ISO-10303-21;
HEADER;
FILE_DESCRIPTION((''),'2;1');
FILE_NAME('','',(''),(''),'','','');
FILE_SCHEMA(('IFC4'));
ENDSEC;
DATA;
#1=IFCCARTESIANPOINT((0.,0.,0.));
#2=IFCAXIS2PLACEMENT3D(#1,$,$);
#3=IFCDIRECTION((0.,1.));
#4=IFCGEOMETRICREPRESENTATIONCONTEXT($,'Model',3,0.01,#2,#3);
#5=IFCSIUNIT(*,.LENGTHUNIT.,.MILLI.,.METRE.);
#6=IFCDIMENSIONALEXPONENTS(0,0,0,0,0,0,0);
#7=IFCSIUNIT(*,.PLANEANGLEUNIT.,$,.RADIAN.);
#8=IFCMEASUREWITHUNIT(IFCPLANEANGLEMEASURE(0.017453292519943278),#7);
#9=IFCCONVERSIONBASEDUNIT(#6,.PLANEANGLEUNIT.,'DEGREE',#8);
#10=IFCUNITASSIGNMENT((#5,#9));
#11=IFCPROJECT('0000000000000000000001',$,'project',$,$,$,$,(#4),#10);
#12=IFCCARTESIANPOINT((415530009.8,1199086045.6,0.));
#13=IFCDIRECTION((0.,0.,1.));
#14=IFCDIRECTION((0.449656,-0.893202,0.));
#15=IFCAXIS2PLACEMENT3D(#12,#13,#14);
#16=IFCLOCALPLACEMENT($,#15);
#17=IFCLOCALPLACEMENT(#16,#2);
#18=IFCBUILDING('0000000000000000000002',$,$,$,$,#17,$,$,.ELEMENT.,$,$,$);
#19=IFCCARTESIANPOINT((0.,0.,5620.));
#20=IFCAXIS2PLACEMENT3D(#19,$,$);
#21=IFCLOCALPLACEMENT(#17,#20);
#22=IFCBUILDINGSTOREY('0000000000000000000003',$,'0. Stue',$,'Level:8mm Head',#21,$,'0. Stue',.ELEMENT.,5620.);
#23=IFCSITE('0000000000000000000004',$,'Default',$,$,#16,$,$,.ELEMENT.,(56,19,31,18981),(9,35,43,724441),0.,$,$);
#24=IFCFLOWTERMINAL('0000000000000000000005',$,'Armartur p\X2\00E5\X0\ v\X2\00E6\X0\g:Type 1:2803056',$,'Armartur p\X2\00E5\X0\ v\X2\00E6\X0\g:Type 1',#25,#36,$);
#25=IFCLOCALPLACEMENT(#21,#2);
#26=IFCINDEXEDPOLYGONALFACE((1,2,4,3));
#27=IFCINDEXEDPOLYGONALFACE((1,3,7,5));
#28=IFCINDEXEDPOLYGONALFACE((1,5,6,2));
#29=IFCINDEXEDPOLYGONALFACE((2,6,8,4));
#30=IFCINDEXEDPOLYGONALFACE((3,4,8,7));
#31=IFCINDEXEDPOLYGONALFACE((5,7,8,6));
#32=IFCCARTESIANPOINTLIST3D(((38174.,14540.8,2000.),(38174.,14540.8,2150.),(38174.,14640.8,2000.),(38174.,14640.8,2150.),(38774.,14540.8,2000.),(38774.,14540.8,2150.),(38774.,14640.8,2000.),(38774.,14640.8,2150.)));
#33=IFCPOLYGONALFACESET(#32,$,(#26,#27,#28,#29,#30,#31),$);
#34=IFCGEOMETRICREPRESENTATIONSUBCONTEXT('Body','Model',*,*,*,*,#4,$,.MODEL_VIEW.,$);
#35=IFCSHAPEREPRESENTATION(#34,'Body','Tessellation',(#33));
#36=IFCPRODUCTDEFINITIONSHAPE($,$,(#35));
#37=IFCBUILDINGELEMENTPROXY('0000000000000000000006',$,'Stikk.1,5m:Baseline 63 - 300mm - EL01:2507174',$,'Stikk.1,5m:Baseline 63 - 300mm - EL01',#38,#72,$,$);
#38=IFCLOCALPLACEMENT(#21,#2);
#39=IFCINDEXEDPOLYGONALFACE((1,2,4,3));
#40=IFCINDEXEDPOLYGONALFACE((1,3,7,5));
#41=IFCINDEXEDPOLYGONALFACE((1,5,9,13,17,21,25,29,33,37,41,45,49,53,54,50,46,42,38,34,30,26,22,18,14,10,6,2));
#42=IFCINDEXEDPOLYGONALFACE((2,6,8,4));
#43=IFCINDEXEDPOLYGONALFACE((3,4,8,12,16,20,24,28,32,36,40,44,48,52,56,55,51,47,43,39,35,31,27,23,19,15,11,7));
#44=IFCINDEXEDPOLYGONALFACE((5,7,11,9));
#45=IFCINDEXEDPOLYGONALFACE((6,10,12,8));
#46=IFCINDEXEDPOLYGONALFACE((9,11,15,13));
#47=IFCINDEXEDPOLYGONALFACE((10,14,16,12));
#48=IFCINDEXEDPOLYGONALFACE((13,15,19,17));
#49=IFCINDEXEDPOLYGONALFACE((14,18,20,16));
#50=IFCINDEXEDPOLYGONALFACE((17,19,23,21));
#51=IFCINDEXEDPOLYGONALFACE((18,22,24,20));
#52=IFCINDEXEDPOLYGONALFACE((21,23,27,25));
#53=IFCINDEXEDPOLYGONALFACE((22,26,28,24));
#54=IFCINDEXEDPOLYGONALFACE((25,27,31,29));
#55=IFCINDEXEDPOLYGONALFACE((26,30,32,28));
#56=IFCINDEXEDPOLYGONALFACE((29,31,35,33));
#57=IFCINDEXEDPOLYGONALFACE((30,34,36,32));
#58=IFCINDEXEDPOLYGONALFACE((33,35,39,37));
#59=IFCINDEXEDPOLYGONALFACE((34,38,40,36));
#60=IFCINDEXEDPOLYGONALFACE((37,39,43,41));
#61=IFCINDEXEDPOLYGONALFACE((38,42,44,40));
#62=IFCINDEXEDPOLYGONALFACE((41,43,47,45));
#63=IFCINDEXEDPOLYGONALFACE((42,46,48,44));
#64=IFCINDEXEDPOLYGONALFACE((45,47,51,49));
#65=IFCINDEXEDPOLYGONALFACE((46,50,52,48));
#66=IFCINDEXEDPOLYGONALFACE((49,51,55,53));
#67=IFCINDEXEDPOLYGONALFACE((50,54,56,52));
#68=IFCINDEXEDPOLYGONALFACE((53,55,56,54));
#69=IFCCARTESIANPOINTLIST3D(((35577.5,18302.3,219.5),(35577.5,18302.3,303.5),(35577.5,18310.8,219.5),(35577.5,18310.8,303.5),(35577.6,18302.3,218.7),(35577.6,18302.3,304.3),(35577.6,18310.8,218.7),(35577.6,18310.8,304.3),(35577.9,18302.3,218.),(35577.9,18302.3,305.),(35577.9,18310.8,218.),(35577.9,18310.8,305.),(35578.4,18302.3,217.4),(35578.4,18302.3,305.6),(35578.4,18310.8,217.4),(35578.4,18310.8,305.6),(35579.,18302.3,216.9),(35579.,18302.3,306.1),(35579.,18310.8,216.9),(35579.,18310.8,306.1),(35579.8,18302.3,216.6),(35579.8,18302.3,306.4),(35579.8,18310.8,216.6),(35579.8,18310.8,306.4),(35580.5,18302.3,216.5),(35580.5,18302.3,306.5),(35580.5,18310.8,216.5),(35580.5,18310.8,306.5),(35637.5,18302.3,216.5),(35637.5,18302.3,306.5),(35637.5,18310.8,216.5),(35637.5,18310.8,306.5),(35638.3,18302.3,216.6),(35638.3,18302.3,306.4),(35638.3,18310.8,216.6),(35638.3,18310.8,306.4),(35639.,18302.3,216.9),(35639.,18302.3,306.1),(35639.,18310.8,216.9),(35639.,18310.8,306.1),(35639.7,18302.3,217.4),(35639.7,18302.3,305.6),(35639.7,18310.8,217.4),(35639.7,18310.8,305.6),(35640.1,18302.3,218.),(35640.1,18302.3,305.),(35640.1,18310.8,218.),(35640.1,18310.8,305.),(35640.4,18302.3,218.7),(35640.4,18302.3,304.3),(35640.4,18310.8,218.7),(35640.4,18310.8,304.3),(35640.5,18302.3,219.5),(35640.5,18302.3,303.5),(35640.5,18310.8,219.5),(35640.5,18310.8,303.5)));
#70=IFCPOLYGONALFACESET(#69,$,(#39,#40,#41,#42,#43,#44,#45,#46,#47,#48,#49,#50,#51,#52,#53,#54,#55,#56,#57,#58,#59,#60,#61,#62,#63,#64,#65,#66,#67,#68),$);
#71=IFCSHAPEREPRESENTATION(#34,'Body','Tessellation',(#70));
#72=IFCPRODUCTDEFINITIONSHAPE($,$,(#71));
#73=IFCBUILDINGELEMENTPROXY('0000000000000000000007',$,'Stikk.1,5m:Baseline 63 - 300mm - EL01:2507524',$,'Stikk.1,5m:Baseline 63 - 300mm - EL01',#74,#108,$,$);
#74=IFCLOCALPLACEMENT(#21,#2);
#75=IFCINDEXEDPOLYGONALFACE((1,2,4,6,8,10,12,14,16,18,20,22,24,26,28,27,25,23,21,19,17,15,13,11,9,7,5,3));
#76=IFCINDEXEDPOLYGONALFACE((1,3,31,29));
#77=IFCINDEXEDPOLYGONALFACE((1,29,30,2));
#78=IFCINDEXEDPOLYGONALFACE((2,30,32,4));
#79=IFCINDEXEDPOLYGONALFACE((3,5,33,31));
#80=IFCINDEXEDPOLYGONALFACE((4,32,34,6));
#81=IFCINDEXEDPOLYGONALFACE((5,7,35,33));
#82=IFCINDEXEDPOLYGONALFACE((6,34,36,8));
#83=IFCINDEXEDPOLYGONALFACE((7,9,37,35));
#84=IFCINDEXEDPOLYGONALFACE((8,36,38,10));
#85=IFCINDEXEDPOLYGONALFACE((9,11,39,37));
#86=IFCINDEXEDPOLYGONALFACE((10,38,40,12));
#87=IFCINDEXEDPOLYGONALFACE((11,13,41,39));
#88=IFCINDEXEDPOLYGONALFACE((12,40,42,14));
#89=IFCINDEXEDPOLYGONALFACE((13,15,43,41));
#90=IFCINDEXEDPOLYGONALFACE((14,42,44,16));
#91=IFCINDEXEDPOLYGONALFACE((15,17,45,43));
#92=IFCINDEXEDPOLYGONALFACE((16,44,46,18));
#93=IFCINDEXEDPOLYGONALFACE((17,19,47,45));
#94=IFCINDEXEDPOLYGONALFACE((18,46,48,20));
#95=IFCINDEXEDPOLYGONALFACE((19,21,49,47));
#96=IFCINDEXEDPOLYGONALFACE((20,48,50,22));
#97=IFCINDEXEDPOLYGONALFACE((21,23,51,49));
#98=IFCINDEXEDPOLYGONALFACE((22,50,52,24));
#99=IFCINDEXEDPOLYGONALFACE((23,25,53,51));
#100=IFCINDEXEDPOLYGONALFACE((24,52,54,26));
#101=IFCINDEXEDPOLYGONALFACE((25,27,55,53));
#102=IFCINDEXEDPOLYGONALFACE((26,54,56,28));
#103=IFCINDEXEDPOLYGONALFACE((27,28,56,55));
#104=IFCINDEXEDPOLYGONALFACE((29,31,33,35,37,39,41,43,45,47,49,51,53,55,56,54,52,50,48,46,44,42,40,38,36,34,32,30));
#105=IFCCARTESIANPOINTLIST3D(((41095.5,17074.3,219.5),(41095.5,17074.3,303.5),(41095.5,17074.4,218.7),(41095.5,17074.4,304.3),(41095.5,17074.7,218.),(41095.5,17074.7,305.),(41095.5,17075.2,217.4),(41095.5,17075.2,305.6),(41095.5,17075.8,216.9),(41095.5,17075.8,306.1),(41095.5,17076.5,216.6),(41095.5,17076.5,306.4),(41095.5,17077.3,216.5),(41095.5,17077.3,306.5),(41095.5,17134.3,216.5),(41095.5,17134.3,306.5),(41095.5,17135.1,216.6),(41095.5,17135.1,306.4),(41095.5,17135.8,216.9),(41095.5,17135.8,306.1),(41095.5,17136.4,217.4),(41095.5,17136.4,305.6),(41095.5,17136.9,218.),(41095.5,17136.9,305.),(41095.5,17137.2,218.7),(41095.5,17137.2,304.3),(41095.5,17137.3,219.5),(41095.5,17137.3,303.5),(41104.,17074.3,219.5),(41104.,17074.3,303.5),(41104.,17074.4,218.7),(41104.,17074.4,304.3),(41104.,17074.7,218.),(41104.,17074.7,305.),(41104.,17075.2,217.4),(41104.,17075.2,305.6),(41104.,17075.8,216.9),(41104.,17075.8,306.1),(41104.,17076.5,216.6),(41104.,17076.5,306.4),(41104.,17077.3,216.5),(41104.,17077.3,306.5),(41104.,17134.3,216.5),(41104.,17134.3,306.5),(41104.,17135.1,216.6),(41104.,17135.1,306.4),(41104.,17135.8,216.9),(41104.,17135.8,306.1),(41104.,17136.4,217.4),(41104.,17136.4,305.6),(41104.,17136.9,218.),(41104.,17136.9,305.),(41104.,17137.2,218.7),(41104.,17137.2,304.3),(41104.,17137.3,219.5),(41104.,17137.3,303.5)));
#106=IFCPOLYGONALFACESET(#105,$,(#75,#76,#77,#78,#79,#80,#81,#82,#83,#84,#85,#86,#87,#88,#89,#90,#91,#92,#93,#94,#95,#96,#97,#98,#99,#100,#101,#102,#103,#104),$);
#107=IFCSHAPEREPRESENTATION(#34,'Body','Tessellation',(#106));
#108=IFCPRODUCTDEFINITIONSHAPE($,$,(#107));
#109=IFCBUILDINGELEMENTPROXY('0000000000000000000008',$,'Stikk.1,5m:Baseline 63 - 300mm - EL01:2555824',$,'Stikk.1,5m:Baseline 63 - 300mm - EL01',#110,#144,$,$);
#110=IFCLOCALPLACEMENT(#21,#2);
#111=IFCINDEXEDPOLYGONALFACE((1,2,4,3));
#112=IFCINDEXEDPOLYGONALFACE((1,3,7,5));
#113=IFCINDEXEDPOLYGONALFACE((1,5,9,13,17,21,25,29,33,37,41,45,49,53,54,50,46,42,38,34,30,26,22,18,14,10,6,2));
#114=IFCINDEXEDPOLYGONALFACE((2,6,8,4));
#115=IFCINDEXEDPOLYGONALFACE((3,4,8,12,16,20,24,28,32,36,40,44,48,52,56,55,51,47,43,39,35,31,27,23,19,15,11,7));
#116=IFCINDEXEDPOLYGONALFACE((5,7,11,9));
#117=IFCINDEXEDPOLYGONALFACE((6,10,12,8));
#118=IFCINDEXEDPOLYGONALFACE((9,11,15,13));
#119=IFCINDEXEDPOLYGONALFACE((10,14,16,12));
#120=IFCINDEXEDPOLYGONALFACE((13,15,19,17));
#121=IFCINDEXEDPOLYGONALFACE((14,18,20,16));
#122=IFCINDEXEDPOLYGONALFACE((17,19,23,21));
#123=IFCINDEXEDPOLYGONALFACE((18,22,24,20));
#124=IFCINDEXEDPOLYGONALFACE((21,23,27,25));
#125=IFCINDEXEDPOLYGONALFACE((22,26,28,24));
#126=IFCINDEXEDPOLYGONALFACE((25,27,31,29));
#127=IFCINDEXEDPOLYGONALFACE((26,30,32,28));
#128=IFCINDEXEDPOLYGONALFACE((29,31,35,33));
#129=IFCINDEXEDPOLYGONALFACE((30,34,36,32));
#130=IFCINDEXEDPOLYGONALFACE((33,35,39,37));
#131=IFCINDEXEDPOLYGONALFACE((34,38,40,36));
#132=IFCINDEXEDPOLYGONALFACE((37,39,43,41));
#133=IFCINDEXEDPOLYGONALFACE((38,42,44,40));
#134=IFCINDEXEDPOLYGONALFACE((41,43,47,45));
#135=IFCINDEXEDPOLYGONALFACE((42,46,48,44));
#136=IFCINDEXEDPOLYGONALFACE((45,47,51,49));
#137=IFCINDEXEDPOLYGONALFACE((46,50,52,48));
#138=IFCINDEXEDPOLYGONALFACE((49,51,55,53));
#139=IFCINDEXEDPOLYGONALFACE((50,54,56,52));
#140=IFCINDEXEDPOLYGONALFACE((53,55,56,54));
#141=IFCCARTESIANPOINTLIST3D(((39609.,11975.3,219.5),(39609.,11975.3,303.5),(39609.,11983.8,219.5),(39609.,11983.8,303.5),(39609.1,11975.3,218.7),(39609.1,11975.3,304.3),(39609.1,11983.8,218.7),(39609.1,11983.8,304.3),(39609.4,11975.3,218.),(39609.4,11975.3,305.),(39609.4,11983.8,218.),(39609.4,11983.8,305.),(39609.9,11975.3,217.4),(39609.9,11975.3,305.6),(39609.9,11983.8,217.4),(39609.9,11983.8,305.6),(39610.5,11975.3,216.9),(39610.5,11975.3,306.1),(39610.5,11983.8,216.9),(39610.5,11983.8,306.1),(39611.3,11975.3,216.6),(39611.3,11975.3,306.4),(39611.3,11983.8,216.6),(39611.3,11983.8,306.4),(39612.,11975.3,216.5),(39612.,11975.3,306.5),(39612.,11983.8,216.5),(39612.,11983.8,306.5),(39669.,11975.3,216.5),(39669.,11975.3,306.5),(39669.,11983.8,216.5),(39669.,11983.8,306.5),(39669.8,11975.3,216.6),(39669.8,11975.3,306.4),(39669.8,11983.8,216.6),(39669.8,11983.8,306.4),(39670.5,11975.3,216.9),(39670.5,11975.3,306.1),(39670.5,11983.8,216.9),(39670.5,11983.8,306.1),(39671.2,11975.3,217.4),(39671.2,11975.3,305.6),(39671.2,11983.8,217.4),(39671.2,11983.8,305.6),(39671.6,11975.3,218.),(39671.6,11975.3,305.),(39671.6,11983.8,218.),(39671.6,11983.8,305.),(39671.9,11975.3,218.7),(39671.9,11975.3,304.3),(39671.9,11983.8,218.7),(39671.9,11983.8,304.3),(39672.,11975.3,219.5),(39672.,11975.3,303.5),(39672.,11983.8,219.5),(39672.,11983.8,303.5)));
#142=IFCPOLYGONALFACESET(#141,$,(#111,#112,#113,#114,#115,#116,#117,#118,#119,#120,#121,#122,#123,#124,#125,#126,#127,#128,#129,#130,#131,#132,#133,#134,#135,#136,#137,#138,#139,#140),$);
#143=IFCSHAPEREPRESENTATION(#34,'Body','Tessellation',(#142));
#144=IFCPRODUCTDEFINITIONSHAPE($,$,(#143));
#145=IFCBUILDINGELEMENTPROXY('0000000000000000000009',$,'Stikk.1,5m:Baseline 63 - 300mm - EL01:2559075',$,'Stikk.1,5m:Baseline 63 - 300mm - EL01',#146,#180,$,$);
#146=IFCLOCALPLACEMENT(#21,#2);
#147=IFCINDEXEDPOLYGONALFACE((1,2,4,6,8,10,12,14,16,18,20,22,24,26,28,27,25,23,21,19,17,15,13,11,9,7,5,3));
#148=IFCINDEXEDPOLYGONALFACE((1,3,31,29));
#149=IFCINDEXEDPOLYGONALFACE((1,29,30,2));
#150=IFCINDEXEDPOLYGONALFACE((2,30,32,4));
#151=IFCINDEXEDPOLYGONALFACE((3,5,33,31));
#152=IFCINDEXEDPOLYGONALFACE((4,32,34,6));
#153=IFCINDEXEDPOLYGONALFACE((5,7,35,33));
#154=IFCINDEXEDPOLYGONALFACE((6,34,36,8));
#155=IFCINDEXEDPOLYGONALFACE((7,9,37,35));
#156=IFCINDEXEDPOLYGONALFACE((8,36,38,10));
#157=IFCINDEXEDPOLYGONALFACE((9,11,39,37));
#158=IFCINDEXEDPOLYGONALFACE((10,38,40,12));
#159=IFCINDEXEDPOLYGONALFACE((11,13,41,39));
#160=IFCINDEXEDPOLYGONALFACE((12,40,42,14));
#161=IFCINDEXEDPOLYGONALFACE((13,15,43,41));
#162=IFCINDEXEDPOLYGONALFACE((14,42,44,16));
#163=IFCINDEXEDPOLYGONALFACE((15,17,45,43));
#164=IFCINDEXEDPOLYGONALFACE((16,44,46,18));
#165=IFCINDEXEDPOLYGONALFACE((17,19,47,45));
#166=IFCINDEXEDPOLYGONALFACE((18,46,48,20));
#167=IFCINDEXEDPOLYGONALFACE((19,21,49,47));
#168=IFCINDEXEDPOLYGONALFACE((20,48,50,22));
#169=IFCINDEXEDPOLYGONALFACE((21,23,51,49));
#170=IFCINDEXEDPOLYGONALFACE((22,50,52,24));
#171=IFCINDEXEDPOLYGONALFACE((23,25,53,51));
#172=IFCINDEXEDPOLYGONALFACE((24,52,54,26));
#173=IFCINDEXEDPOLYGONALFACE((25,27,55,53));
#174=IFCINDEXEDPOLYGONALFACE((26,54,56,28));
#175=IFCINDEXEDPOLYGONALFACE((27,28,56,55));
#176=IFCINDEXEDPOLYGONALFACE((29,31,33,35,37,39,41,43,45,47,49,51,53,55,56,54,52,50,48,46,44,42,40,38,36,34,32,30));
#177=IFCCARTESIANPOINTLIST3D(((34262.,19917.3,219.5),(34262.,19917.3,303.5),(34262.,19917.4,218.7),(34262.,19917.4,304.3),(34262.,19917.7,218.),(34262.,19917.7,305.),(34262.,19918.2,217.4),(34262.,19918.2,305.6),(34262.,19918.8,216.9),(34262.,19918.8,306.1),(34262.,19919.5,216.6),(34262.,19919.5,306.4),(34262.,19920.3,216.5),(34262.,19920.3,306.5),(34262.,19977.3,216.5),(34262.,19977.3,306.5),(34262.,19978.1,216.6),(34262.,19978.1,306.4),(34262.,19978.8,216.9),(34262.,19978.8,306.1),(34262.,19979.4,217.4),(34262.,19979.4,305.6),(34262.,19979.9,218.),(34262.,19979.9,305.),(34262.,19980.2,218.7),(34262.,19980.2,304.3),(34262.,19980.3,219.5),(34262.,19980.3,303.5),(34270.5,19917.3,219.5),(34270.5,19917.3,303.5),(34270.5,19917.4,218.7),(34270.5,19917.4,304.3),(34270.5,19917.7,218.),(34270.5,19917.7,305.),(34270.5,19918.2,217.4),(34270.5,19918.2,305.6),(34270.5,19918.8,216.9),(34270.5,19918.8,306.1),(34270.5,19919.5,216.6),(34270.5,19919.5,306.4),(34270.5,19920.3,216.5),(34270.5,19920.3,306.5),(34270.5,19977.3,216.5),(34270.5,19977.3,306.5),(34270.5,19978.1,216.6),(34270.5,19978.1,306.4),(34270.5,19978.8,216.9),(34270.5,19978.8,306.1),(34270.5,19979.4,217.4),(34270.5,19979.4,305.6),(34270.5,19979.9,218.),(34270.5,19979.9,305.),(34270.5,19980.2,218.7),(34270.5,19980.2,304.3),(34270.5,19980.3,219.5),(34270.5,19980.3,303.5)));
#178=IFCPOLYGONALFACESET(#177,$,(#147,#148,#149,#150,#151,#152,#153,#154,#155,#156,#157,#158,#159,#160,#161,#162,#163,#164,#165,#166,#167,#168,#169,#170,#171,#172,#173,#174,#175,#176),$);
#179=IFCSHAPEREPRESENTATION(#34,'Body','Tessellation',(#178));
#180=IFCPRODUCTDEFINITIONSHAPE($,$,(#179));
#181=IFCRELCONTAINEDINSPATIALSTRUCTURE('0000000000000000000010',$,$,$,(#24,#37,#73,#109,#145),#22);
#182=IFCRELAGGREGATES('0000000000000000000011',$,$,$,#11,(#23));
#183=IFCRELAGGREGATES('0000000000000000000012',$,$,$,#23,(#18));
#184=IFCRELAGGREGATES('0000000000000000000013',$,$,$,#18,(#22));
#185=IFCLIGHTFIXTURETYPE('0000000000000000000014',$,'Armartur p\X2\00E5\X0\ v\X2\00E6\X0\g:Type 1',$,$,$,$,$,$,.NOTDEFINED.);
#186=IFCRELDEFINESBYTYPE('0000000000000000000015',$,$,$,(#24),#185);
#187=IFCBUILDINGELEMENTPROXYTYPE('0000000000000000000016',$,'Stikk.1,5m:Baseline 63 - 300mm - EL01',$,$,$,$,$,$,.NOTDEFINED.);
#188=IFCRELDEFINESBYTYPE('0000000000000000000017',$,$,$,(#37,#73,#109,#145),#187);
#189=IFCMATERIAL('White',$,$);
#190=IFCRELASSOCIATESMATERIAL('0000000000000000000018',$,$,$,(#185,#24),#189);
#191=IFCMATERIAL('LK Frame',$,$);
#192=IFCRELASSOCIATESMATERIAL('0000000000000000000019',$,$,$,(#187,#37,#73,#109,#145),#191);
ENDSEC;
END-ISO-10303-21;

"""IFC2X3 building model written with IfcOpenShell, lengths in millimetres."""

from ifc_helpers import new_model, entity, si_unit, converted_unit, direction, frame, frame_2d, origin, origin_2d_with_axis, place, context, subcontext, project, spatial, polyline, circle_curve, parameter, trimmed, segment, composite_curve, rectangle, outline, extrude, source, transform, mapped, material, type_object, type_shapes, element, save


model = new_model("IFC2X3")

# Units and contexts
model_context = context("Model", 3, precision=0.01, world=origin(), true_north=direction((0.0, 1.0)))
body_context = subcontext(model_context, "Body", "Model", "MODEL_VIEW")
ifc_project = project(units=[si_unit("LENGTHUNIT", "METRE", prefix="MILLI"), converted_unit("PLANEANGLEUNIT", "DEGREE", entity("IfcPlaneAngleMeasure", 0.017453292519943278), si_unit("PLANEANGLEUNIT", "RADIAN"), dimensions=[0, 0, 0, 0, 0, 0, 0])], contexts=[model_context])

# Site, building, storey
site_placement = place(None, frame((415530009.8, 1199086045.6, 0.0), z_axis=(0.0, 0.0, 1.0), x_axis=(0.449656, -0.893202, 0.0)))
site = spatial("IfcSite", under=ifc_project, at=site_placement, Name="Default", CompositionType="ELEMENT", RefLatitude=(56, 19, 31, 18981), RefLongitude=(9, 35, 43, 724441), RefElevation=0.0)
building_placement = place(site_placement, origin())
building = spatial("IfcBuilding", under=site, at=building_placement, CompositionType="ELEMENT")
storey_placement = place(building_placement, frame((0.0, 0.0, 5620.0)))
storey = spatial("IfcBuildingStorey", under=building, at=storey_placement, Name="0. Stue", ObjectType="Level:8mm Head", LongName="0. Stue", CompositionType="ELEMENT", Elevation=5620.0)

# Flow terminal
ifc_material_1 = material(Name="White")
light_fixture_type_1 = type_object("IfcLightFixtureType", Name="Armartur på væg:Type 1", PredefinedType="NOTDEFINED", material=ifc_material_1)
shared_shape_1 = source(origin(), body_context, "Body", "SweptSolid", [
    extrude(rectangle(XDim=600.0, YDim=100.0, at=origin_2d_with_axis()), frame((125.0, 50.0, 0.0), z_axis=(0.0, 0.0, 1.0), x_axis=(-1.0, 0.0, 0.0)), (0.0, 0.0, 1.0), 150.0),
])
type_shapes(light_fixture_type_1, [shared_shape_1])
flow_terminal_1_placement = place(storey_placement, frame((38349.0, 14540.8, 2000.0)))
element("IfcFlowTerminal", 1, at=flow_terminal_1_placement, inside=storey, type_object=light_fixture_type_1, material=ifc_material_1, Name="Armartur på væg:Type 1:2803056", ObjectType="Armartur på væg:Type 1", context=body_context, shape_type="MappedRepresentation", body=[
    mapped(shared_shape_1, transform((0.0, 0.0, 0.0), scale=1.0)),
])

# Building element proxies
ifc_material_2 = material(Name="LK Frame")
building_element_proxy_type_1 = type_object("IfcBuildingElementProxyType", Name="Stikk.1,5m:Baseline 63 - 300mm - EL01", PredefinedType="NOTDEFINED", material=ifc_material_2)
shared_shape_2 = source(origin(), body_context, "Body", "SweptSolid", [
    extrude(outline(composite_curve([segment(polyline([(-42.0, -31.5), (42.0, -31.5)]), True, "CONTINUOUS"), segment(trimmed(circle_curve(frame_2d((42.0, -28.5), x_axis=(-1.0, 0.0)), 3.0), [parameter(90.0)], [parameter(180.0)], True, "PARAMETER"), True, "CONTINUOUS"), segment(polyline([(45.0, -28.5), (45.0, 28.5)]), True, "CONTINUOUS"), segment(trimmed(circle_curve(frame_2d((42.0, 28.5), x_axis=(-1.0, 0.0)), 3.0), [parameter(180.0)], [parameter(270.0)], True, "PARAMETER"), True, "CONTINUOUS"), segment(polyline([(42.0, 31.5), (-42.0, 31.5)]), True, "CONTINUOUS"), segment(trimmed(circle_curve(frame_2d((-42.0, 28.5), x_axis=(1.0, 0.0)), 3.0), [parameter(90.0)], [parameter(180.0)], True, "PARAMETER"), True, "CONTINUOUS"), segment(polyline([(-45.0, 28.5), (-45.0, -28.5)]), True, "CONTINUOUS"), segment(trimmed(circle_curve(frame_2d((-42.0, -28.5), x_axis=(1.0, 0.0)), 3.0), [parameter(180.0)], [parameter(270.0)], True, "PARAMETER"), True, "CONTINUOUS")], self_intersect=False)), frame((0.0, -38.5, 0.0), z_axis=(0.0, 0.0, 1.0), x_axis=(0.0, 1.0, 0.0)), (0.0, 0.0, 1.0), 8.5),
])
type_shapes(building_element_proxy_type_1, [shared_shape_2])
for number, where, z_axis, x_axis, name in (
    (2, (35609.0, 18310.8, 300.0), (0.0, -1.0, 0.0), (1.0, 0.0, 0.0), "Stikk.1,5m:Baseline 63 - 300mm - EL01:2507174"),
    (3, (41104.0, 17105.8, 300.0), (-1.0, 0.0, 0.0), (0.0, -1.0, 0.0), "Stikk.1,5m:Baseline 63 - 300mm - EL01:2507524"),
    (4, (39640.5, 11983.8, 300.0), (0.0, -1.0, 0.0), (1.0, 0.0, 0.0), "Stikk.1,5m:Baseline 63 - 300mm - EL01:2555824"),
    (5, (34270.5, 19948.8, 300.0), (-1.0, 0.0, 0.0), (0.0, -1.0, 0.0), "Stikk.1,5m:Baseline 63 - 300mm - EL01:2559075"),
):
    element("IfcBuildingElementProxy", number, at=place(storey_placement, frame(where, z_axis=z_axis, x_axis=x_axis)), inside=storey, type_object=building_element_proxy_type_1, material=ifc_material_2, Name=name, ObjectType="Stikk.1,5m:Baseline 63 - 300mm - EL01", context=body_context, shape_type="MappedRepresentation", body=[
        mapped(shared_shape_2, transform((0.0, 0.0, 0.0), scale=1.0)),
    ])

save(model, "model.ifc")
